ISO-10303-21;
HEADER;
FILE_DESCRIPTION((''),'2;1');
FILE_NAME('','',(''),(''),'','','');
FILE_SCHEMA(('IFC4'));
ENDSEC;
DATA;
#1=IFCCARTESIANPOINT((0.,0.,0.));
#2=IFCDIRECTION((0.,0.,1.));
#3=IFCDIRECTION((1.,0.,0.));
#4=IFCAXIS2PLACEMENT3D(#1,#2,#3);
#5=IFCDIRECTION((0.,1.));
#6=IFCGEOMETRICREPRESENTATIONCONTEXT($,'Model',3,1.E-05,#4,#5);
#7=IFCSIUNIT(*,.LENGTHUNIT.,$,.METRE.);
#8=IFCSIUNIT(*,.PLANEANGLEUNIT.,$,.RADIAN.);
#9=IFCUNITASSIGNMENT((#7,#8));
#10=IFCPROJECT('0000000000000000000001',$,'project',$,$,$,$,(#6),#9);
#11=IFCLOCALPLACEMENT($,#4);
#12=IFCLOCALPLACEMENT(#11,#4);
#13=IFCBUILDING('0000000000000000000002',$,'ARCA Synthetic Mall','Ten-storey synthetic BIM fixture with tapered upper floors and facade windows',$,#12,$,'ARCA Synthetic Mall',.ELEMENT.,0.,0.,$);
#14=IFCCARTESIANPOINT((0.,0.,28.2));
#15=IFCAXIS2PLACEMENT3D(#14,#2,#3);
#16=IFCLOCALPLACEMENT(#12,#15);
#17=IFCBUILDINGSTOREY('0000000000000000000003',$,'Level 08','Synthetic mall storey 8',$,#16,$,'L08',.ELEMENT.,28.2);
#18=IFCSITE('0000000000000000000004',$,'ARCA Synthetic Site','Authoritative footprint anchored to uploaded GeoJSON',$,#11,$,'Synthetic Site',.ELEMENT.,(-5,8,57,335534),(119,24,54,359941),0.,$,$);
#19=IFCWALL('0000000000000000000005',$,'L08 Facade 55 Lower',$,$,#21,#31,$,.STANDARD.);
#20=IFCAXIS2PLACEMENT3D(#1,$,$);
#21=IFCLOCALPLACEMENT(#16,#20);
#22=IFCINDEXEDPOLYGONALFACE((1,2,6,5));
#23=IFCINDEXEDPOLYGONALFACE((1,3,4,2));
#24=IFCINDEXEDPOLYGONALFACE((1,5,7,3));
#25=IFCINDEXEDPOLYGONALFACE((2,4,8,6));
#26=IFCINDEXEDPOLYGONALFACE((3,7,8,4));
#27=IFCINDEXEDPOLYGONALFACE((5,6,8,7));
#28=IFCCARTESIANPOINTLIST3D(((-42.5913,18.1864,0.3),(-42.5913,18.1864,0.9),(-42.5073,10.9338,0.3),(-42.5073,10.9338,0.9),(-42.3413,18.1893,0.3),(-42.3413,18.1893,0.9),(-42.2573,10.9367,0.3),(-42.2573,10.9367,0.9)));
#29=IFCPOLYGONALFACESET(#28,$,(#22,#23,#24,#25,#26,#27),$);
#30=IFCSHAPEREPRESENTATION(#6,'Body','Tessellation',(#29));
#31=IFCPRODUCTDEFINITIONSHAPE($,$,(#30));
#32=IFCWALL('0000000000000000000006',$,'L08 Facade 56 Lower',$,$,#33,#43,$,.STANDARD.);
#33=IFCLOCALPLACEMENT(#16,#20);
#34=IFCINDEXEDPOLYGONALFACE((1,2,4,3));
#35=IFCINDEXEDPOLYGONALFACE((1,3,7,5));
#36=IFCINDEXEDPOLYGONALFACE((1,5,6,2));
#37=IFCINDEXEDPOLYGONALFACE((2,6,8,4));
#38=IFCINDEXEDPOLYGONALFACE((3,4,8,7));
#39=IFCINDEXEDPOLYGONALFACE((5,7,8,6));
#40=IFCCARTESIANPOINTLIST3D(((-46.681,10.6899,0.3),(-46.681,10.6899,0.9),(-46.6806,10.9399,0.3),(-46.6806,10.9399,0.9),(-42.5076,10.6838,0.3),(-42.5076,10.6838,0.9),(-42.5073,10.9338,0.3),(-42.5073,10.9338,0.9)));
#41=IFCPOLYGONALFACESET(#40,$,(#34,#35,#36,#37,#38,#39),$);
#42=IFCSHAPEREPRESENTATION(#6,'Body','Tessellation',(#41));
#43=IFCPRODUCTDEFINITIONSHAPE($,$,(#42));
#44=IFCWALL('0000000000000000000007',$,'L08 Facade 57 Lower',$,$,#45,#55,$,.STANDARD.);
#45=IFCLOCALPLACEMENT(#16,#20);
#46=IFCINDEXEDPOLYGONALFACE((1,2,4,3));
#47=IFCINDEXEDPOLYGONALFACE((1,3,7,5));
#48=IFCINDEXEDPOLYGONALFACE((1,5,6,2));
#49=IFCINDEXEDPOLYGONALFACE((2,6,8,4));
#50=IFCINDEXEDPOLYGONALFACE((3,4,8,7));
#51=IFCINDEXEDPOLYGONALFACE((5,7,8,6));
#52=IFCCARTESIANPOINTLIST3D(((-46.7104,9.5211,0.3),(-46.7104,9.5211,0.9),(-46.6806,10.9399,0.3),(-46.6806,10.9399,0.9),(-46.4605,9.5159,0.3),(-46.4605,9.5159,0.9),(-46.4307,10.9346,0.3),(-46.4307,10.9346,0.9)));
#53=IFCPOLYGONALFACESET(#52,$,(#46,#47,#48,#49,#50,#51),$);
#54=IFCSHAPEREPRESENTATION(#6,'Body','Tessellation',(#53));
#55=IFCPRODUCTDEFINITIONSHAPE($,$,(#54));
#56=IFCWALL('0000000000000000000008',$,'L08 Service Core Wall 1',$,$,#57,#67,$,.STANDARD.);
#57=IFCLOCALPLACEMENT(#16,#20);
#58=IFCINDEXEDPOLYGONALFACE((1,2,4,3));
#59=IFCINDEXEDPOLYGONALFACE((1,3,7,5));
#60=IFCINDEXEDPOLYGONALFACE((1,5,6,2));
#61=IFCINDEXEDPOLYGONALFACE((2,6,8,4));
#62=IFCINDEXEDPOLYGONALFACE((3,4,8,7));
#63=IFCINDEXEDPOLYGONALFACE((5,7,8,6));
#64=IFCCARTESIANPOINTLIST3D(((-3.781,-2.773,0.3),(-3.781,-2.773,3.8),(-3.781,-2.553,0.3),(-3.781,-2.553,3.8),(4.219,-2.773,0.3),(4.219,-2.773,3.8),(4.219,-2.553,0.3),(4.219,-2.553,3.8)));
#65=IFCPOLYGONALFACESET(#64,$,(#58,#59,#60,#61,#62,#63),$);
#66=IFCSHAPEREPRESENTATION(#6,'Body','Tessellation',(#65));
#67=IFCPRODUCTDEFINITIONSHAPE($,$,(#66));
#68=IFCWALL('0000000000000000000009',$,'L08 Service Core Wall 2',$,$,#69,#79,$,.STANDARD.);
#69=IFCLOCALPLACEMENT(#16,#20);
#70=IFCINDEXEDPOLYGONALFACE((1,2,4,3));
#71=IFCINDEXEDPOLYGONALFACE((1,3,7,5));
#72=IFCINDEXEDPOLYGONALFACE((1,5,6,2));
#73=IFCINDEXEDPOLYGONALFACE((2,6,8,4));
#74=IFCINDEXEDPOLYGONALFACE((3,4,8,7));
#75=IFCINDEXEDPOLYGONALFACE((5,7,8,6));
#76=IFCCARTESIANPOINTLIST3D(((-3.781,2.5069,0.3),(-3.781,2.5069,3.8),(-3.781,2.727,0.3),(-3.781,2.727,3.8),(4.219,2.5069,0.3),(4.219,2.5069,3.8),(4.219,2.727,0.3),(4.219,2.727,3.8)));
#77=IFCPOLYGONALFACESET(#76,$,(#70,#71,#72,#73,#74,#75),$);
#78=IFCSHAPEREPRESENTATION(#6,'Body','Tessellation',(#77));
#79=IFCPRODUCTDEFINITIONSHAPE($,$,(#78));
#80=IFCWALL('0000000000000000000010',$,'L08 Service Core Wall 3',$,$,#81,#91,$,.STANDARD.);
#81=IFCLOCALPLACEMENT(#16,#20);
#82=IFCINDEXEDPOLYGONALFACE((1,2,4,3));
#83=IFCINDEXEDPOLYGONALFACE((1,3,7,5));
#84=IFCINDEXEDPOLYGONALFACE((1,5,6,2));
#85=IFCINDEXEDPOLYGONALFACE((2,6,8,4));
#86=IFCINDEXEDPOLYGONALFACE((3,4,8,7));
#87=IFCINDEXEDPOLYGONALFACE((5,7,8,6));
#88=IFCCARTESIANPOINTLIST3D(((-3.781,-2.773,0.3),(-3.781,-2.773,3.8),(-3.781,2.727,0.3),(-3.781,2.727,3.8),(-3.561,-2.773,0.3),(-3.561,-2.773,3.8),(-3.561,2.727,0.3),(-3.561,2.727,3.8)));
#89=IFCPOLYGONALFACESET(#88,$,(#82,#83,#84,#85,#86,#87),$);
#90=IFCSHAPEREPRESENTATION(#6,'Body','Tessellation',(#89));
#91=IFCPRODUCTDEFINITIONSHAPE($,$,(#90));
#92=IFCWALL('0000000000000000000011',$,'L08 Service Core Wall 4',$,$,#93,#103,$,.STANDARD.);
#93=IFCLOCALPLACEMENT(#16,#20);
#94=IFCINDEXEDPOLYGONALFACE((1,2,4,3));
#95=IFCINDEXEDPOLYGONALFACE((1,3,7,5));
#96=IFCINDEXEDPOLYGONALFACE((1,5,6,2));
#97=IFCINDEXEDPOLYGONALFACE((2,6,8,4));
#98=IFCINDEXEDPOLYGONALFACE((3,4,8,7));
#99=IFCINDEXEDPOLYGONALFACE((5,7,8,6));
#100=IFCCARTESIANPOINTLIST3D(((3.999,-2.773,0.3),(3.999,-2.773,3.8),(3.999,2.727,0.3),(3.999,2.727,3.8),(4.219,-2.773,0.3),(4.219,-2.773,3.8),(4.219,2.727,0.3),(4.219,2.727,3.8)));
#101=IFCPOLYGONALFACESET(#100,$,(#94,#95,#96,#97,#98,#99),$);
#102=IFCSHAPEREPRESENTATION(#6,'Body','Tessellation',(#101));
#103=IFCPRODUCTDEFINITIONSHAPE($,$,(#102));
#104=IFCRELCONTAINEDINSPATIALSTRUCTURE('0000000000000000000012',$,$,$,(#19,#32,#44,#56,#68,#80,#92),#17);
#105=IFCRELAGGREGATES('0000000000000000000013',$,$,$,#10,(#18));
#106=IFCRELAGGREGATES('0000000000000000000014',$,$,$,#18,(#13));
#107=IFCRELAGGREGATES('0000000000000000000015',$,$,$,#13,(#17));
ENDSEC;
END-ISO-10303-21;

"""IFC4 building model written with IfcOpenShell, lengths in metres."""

from ifc_helpers import new_model, si_unit, direction, frame, origin_with_axes, place, context, project, spatial, polyline, outline, extrude, element, save


model = new_model("IFC4")

# Units and contexts
model_context = context("Model", 3, precision=1e-05, world=origin_with_axes(), true_north=direction((0.0, 1.0)))
ifc_project = project(units=[si_unit("LENGTHUNIT", "METRE"), si_unit("PLANEANGLEUNIT", "RADIAN")], contexts=[model_context])

# Site, building, storey
site_placement = place(None, origin_with_axes())
site = spatial("IfcSite", under=ifc_project, at=site_placement, Name="ARCA Synthetic Site", Description="Authoritative footprint anchored to uploaded GeoJSON", LongName="Synthetic Site", CompositionType="ELEMENT", RefLatitude=(-5, 8, 57, 335534), RefLongitude=(119, 24, 54, 359941), RefElevation=0.0)
building_placement = place(site_placement, origin_with_axes())
building = spatial("IfcBuilding", under=site, at=building_placement, Name="ARCA Synthetic Mall", Description="Ten-storey synthetic BIM fixture with tapered upper floors and facade windows", LongName="ARCA Synthetic Mall", CompositionType="ELEMENT", ElevationOfRefHeight=0.0, ElevationOfTerrain=0.0)
storey_placement = place(building_placement, frame((0.0, 0.0, 28.2), z_axis=(0.0, 0.0, 1.0), x_axis=(1.0, 0.0, 0.0)))
storey = spatial("IfcBuildingStorey", under=building, at=storey_placement, Name="Level 08", Description="Synthetic mall storey 8", LongName="L08", CompositionType="ELEMENT", Elevation=28.2)

# Walls
wall_1_placement = place(storey_placement, frame((0.0, 0.0, 0.3), z_axis=(0.0, 0.0, 1.0), x_axis=(1.0, 0.0, 0.0)))
element("IfcWall", 1, at=wall_1_placement, inside=storey, Name="L08 Facade 55 Lower", PredefinedType="STANDARD", context=model_context, shape_type="SweptSolid", body=[
    extrude(outline(polyline([(-42.5913, 18.1864), (-42.5073, 10.9338), (-42.2573, 10.9367), (-42.3413, 18.1893), (-42.5913, 18.1864)])), origin_with_axes(), (0.0, 0.0, 1.0), 0.6),
])
wall_2_placement = place(storey_placement, frame((0.0, 0.0, 0.3), z_axis=(0.0, 0.0, 1.0), x_axis=(1.0, 0.0, 0.0)))
element("IfcWall", 2, at=wall_2_placement, inside=storey, Name="L08 Facade 56 Lower", PredefinedType="STANDARD", context=model_context, shape_type="SweptSolid", body=[
    extrude(outline(polyline([(-42.5073, 10.9338), (-46.6806, 10.9399), (-46.681, 10.6899), (-42.5076, 10.6838), (-42.5073, 10.9338)])), origin_with_axes(), (0.0, 0.0, 1.0), 0.6),
])
wall_3_placement = place(storey_placement, frame((0.0, 0.0, 0.3), z_axis=(0.0, 0.0, 1.0), x_axis=(1.0, 0.0, 0.0)))
element("IfcWall", 3, at=wall_3_placement, inside=storey, Name="L08 Facade 57 Lower", PredefinedType="STANDARD", context=model_context, shape_type="SweptSolid", body=[
    extrude(outline(polyline([(-46.6806, 10.9399), (-46.7104, 9.5211), (-46.4605, 9.5159), (-46.4307, 10.9346), (-46.6806, 10.9399)])), origin_with_axes(), (0.0, 0.0, 1.0), 0.6),
])
wall_4_placement = place(storey_placement, frame((0.0, 0.0, 0.3), z_axis=(0.0, 0.0, 1.0), x_axis=(1.0, 0.0, 0.0)))
element("IfcWall", 4, at=wall_4_placement, inside=storey, Name="L08 Service Core Wall 1", PredefinedType="STANDARD", context=model_context, shape_type="SweptSolid", body=[
    extrude(outline(polyline([(-3.781, -2.7731), (4.219, -2.7731), (4.219, -2.553), (-3.781, -2.553), (-3.781, -2.7731)])), origin_with_axes(), (0.0, 0.0, 1.0), 3.5),
])
wall_5_placement = place(storey_placement, frame((0.0, 0.0, 0.3), z_axis=(0.0, 0.0, 1.0), x_axis=(1.0, 0.0, 0.0)))
element("IfcWall", 5, at=wall_5_placement, inside=storey, Name="L08 Service Core Wall 2", PredefinedType="STANDARD", context=model_context, shape_type="SweptSolid", body=[
    extrude(outline(polyline([(-3.781, 2.5069), (4.219, 2.5069), (4.219, 2.7269), (-3.781, 2.7269), (-3.781, 2.5069)])), origin_with_axes(), (0.0, 0.0, 1.0), 3.5),
])
wall_6_placement = place(storey_placement, frame((0.0, 0.0, 0.3), z_axis=(0.0, 0.0, 1.0), x_axis=(1.0, 0.0, 0.0)))
element("IfcWall", 6, at=wall_6_placement, inside=storey, Name="L08 Service Core Wall 3", PredefinedType="STANDARD", context=model_context, shape_type="SweptSolid", body=[
    extrude(outline(polyline([(-3.781, -2.7731), (-3.561, -2.7731), (-3.561, 2.7269), (-3.781, 2.7269), (-3.781, -2.7731)])), origin_with_axes(), (0.0, 0.0, 1.0), 3.5),
])
wall_7_placement = place(storey_placement, frame((0.0, 0.0, 0.3), z_axis=(0.0, 0.0, 1.0), x_axis=(1.0, 0.0, 0.0)))
element("IfcWall", 7, at=wall_7_placement, inside=storey, Name="L08 Service Core Wall 4", PredefinedType="STANDARD", context=model_context, shape_type="SweptSolid", body=[
    extrude(outline(polyline([(3.999, -2.7731), (4.219, -2.7731), (4.219, 2.7269), (3.999, 2.7269), (3.999, -2.7731)])), origin_with_axes(), (0.0, 0.0, 1.0), 3.5),
])

save(model, "model.ifc")
